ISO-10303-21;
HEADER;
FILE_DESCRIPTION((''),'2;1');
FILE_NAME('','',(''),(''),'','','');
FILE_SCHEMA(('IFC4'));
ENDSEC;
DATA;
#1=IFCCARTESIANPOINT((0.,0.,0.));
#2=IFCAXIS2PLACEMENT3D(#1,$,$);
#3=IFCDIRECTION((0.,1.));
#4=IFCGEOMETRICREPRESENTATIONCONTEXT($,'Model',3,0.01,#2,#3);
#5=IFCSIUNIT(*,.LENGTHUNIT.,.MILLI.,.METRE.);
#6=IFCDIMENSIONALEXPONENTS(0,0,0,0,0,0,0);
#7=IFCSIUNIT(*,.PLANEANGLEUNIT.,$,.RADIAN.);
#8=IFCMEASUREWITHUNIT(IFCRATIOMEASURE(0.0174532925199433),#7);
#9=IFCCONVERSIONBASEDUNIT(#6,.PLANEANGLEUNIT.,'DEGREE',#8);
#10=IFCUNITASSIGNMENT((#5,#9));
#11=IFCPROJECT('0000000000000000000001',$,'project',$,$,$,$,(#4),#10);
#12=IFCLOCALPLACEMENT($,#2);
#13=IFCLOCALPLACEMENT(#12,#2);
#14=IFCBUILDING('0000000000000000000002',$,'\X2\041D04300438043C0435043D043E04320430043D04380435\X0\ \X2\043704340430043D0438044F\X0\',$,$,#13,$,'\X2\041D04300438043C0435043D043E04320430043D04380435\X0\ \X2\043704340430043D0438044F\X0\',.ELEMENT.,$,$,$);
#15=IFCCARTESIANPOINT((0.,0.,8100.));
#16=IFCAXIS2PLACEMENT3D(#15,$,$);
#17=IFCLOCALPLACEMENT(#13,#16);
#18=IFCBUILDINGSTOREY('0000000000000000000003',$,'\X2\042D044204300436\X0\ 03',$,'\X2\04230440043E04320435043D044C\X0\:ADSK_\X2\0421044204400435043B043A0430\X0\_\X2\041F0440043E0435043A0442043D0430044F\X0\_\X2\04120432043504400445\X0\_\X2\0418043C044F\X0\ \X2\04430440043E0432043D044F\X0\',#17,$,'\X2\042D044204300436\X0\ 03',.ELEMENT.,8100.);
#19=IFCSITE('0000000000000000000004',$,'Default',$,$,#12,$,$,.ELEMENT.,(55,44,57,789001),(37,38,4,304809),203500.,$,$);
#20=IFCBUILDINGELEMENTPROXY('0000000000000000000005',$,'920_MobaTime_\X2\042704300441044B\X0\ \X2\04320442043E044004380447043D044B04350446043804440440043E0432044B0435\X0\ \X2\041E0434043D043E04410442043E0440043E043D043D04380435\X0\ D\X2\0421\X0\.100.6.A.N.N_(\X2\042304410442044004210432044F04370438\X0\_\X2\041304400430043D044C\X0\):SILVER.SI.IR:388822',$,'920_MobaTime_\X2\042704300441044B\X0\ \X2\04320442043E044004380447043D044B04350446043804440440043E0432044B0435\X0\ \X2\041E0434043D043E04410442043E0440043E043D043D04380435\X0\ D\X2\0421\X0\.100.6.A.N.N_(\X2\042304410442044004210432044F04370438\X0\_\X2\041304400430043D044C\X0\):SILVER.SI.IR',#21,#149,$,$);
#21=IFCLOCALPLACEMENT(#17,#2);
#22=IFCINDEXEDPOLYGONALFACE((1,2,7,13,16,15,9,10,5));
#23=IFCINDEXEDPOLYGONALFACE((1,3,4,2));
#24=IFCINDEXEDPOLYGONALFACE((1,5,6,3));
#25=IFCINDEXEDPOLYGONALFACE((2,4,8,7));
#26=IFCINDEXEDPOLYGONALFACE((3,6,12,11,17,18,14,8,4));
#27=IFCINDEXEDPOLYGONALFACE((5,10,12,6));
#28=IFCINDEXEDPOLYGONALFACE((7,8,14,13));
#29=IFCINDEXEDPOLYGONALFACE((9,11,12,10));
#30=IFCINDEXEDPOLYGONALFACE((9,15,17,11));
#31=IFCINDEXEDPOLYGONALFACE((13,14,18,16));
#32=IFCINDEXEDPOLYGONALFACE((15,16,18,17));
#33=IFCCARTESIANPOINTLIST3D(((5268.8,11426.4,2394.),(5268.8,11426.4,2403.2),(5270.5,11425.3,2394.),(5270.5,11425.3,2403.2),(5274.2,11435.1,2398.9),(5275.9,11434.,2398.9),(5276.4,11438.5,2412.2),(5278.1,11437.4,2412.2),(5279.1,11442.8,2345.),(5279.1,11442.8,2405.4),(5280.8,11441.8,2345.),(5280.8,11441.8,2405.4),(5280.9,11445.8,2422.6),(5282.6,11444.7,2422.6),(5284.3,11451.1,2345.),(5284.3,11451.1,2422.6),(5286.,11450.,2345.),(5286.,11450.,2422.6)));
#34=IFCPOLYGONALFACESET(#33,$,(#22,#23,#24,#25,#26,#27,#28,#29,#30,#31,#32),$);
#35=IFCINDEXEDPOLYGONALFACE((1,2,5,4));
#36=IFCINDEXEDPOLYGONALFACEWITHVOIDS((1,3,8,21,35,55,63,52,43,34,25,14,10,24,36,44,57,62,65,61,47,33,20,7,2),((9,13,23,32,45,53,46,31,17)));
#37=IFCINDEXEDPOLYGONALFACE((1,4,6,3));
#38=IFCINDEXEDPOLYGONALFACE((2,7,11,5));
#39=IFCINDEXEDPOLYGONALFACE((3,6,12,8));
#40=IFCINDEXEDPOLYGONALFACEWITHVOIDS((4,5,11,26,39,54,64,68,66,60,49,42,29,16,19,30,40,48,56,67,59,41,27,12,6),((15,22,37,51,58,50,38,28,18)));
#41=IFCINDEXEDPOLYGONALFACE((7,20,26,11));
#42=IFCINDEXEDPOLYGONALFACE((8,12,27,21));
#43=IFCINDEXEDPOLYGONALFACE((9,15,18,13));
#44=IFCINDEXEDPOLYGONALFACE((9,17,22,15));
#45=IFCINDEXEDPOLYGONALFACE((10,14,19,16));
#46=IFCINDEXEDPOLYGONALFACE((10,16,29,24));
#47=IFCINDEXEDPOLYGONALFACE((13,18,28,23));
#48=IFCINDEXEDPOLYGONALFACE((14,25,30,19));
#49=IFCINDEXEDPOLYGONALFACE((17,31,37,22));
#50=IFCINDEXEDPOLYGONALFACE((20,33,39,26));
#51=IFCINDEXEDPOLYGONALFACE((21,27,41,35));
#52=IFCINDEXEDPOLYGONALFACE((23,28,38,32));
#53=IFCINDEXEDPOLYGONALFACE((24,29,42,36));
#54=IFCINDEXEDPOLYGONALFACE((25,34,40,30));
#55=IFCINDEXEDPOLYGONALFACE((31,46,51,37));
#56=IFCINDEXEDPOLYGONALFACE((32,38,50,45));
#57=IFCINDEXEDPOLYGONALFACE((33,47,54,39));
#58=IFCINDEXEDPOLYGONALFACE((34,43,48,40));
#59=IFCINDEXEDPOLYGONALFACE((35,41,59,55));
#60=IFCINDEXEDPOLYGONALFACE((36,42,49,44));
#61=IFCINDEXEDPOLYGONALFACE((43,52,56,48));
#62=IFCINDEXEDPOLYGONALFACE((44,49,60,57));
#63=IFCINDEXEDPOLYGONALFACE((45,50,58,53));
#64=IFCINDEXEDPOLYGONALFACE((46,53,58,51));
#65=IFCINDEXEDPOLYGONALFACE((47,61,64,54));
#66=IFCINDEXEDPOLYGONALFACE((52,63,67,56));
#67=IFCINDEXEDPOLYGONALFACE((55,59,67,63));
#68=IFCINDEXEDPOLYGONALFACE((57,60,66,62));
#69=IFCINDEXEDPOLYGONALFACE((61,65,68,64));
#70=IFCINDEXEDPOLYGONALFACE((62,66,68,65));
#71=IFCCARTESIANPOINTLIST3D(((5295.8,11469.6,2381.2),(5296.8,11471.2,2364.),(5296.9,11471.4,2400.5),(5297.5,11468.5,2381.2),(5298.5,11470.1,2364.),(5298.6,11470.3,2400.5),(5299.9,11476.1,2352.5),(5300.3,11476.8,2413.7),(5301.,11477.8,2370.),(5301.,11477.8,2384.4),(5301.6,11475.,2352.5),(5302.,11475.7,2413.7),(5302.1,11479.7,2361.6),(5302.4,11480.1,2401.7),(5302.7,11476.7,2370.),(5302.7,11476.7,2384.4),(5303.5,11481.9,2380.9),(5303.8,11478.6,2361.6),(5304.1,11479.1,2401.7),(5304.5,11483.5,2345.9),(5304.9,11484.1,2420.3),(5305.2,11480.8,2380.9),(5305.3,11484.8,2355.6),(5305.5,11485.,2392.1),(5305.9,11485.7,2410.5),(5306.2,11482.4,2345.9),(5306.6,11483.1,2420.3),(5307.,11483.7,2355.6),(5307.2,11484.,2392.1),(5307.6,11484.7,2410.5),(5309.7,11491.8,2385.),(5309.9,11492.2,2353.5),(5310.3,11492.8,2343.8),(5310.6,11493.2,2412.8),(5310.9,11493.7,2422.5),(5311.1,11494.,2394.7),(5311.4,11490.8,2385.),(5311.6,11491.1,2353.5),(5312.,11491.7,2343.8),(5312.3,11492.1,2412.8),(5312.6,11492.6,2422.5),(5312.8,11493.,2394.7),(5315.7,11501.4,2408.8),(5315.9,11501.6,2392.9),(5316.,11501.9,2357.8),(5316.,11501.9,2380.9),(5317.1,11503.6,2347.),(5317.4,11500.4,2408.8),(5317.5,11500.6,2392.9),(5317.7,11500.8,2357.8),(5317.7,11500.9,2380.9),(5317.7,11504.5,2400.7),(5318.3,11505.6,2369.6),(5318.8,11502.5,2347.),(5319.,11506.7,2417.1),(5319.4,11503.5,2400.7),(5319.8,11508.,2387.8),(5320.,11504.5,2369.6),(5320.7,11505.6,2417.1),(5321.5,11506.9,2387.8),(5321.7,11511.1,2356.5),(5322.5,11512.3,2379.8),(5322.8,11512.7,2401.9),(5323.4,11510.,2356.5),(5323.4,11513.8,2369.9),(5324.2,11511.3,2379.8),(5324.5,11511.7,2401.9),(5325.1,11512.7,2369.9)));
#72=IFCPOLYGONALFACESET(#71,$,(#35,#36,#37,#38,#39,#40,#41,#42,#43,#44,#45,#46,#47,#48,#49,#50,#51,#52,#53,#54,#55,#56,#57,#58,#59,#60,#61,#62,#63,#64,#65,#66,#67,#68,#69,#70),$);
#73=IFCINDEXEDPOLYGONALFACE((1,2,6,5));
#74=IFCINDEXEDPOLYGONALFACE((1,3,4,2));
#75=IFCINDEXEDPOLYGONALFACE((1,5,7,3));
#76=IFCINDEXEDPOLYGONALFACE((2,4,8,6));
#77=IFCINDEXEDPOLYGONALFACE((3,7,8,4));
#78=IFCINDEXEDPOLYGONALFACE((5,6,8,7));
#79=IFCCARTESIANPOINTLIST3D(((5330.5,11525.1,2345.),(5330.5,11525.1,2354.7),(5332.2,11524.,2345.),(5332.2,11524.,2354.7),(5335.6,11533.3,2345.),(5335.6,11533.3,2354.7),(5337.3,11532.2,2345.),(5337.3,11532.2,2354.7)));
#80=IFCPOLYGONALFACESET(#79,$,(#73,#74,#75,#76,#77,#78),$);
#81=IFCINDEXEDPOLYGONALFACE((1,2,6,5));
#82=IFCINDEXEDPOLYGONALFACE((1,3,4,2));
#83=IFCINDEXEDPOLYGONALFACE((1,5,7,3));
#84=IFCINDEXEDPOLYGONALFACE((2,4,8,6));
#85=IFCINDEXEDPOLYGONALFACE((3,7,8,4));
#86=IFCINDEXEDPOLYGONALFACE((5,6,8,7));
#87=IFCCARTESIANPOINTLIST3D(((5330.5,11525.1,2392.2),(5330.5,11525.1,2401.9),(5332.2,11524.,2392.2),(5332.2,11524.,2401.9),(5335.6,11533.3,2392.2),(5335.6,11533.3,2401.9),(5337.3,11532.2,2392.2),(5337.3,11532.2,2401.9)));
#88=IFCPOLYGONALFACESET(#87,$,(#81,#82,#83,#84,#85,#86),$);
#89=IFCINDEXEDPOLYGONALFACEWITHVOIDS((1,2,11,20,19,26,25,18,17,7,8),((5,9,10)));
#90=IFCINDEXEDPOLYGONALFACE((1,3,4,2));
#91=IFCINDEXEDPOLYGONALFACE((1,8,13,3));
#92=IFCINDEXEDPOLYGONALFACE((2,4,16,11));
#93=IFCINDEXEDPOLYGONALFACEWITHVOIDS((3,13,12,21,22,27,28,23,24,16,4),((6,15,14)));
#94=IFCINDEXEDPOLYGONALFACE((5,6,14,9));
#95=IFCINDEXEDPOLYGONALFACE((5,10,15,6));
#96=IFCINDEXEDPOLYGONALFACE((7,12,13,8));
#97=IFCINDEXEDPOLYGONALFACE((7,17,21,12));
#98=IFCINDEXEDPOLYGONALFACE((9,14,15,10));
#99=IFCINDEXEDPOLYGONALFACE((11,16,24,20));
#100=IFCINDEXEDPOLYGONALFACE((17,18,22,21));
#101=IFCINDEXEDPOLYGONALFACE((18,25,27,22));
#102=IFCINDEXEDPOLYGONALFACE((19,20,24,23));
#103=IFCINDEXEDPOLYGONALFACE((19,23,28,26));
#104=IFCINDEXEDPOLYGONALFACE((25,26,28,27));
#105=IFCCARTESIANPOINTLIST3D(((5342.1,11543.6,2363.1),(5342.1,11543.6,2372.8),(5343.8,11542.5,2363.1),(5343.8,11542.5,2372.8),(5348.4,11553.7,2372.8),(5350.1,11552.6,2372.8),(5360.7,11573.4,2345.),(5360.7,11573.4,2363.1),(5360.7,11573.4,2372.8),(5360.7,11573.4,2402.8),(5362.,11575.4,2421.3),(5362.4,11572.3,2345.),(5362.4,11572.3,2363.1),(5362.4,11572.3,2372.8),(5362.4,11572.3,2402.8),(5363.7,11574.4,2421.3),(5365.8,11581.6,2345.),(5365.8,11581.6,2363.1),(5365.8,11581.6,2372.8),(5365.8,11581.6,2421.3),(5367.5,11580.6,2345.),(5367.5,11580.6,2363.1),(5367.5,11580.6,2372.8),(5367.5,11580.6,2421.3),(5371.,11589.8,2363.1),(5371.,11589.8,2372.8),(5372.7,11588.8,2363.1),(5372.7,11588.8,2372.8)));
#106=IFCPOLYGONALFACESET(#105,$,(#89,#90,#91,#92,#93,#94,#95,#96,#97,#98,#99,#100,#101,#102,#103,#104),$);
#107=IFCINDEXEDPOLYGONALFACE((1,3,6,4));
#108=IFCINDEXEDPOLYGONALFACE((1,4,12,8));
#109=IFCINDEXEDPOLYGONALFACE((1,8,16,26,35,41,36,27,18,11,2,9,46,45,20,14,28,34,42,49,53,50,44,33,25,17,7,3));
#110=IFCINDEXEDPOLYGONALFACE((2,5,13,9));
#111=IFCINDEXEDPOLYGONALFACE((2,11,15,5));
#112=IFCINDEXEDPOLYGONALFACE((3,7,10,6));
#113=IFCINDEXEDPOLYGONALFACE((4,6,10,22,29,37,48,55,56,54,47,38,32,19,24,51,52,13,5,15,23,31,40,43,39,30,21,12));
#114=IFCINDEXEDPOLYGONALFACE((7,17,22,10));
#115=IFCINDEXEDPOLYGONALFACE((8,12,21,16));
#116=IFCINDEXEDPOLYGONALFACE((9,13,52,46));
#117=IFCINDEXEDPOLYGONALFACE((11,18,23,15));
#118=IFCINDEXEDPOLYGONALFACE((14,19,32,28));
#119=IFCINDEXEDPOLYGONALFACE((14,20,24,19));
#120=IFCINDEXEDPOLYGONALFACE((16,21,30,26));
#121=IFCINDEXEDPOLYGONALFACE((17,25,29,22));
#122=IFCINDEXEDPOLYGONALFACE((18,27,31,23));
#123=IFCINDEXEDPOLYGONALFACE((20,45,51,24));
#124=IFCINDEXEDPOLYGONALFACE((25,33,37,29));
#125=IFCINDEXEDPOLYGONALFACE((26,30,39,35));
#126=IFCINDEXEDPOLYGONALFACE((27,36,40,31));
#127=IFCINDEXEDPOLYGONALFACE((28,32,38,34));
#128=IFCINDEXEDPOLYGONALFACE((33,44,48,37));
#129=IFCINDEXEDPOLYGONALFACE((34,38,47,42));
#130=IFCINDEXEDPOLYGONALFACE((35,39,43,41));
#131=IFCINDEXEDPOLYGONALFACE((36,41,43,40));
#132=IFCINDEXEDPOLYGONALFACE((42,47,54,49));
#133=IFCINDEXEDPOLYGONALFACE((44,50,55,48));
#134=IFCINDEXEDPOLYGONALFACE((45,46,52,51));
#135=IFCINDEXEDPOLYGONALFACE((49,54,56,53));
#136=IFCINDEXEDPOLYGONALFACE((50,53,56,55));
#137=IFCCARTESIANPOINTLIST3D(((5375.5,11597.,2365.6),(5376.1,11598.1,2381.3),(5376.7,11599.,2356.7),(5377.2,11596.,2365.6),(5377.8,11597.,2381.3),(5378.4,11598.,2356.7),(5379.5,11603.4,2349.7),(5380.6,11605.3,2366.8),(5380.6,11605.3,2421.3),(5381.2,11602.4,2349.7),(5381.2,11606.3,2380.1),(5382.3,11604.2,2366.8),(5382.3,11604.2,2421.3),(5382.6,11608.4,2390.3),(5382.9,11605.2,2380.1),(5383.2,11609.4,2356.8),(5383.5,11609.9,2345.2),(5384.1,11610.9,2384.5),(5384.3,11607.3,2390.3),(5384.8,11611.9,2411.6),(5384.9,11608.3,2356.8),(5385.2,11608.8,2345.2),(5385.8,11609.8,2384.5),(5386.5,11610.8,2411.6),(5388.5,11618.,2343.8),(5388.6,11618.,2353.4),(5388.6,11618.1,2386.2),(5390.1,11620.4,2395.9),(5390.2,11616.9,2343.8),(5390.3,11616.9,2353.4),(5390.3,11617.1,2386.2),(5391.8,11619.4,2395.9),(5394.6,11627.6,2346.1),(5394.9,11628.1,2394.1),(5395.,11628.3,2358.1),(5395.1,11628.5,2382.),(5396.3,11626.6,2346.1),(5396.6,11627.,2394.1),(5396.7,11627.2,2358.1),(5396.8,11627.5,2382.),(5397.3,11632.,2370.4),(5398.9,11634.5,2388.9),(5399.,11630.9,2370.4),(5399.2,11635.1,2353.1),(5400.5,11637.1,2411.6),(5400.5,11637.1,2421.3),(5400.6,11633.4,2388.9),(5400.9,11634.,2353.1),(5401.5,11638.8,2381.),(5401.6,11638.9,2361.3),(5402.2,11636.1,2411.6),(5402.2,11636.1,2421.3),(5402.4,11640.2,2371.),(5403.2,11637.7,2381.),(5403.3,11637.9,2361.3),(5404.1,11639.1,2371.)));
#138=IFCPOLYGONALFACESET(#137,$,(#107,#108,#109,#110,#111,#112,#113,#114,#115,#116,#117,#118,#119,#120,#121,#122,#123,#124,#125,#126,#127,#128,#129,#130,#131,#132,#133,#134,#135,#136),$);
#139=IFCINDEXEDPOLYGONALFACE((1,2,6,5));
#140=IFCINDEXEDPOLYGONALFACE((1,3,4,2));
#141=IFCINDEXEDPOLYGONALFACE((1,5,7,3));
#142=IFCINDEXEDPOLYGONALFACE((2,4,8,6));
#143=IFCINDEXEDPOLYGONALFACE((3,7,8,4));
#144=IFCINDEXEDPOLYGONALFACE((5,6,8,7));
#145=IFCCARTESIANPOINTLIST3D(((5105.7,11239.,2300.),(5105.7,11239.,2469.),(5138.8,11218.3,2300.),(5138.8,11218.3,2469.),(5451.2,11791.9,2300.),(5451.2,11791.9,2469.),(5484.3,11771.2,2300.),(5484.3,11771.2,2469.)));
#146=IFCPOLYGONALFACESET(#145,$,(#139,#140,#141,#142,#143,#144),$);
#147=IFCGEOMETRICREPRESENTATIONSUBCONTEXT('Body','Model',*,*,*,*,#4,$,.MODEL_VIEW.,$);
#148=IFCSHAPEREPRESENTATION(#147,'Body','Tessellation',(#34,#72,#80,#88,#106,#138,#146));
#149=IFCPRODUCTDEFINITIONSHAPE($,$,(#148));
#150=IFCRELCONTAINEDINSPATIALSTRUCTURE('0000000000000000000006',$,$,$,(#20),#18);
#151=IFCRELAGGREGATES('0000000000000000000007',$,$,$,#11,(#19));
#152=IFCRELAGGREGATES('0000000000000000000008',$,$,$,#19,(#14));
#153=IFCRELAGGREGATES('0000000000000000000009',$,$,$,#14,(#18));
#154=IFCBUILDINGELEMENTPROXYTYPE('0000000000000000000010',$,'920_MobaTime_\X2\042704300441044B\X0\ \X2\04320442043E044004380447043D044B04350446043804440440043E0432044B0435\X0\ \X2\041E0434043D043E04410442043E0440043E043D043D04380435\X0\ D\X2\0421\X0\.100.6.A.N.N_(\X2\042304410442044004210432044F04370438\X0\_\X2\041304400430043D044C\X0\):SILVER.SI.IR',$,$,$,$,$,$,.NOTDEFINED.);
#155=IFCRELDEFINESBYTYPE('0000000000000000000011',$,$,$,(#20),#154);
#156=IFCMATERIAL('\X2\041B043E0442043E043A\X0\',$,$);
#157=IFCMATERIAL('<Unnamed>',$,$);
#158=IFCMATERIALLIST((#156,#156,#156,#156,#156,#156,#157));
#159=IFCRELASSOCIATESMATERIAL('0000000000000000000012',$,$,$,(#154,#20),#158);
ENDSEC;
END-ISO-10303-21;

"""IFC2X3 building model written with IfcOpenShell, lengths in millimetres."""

from ifc_helpers import new_model, entity, si_unit, converted_unit, direction, frame, origin, origin_2d_with_axis, place, context, subcontext, project, spatial, polyline, rectangle, outline, extrude, source, transform, mapped, material, material_list, type_object, type_shapes, element, save


model = new_model("IFC2X3")

# Units and contexts
model_context = context("Model", 3, precision=0.01, world=origin(), true_north=direction((0.0, 1.0)))
body_context = subcontext(model_context, "Body", "Model", "MODEL_VIEW")
ifc_project = project(units=[si_unit("LENGTHUNIT", "METRE", prefix="MILLI"), converted_unit("PLANEANGLEUNIT", "DEGREE", entity("IfcRatioMeasure", 0.0174532925199433), si_unit("PLANEANGLEUNIT", "RADIAN"), dimensions=[0, 0, 0, 0, 0, 0, 0])], contexts=[model_context])

# Site, building, storey
site_placement = place(None, origin())
site = spatial("IfcSite", under=ifc_project, at=site_placement, Name="Default", CompositionType="ELEMENT", RefLatitude=(55, 44, 57, 789001), RefLongitude=(37, 38, 4, 304809), RefElevation=203500.0)
building_placement = place(site_placement, origin())
building = spatial("IfcBuilding", under=site, at=building_placement, Name="Наименование здания", LongName="Наименование здания", CompositionType="ELEMENT")
storey_placement = place(building_placement, frame((0.0, 0.0, 8100.0)))
storey = spatial("IfcBuildingStorey", under=building, at=storey_placement, Name="Этаж 03", ObjectType="Уровень:ADSK_Стрелка_Проектная_Вверх_Имя уровня", LongName="Этаж 03", CompositionType="ELEMENT", Elevation=8100.0)

# Building element proxy
ifc_material_1 = material(Name="Лоток")
ifc_material_2 = material(Name="<Unnamed>")
ifc_material_list_1 = material_list([ifc_material_1, ifc_material_1, ifc_material_1, ifc_material_1, ifc_material_1, ifc_material_1, ifc_material_2])
building_element_proxy_type = type_object("IfcBuildingElementProxyType", Name="920_MobaTime_Часы вторичныецифровые Односторонние DС.100.6.A.N.N_(УстрСвязи_Грань):SILVER.SI.IR", PredefinedType="NOTDEFINED", material=ifc_material_list_1)
shared_shape = source(origin(), body_context, "Body", "SweptSolid", [
    extrude(outline(polyline([(-49.3, -13.1), (28.2, -13.1), (28.2, -6.8), (17.9, 1.8), (8.8, 16.0), (-0.3, 16.0), (4.6, 5.8), (11.1, -3.4), (-49.3, -3.4), (-49.3, -13.1)])), frame((-64.6, 9.8, 39.0), z_axis=(0.0, 0.0, 1.0), x_axis=(0.0, 1.0, 0.0)), (0.0, 0.0, 1.0), 2.0),
    extrude(outline(polyline([(2.2, -27.6), (19.0, -27.6), (30.5, -16.1), (33.3, -4.9), (31.0, 5.8), (21.8, 17.2), (5.2, 27.3), (-11.1, 33.0), (-24.0, 32.7), (-33.6, 27.6), (-40.3, 18.6), (-42.8, 5.7), (-38.0, -6.3), (-27.2, -14.9), (-17.5, -17.7), (-8.2, -16.4), (-0.3, -11.9), (5.1, -4.5), (7.3, 6.2), (4.0, 17.2), (18.4, 7.3), (23.6, -2.4), (22.0, -11.4), (14.2, -18.4), (5.3, -18.3), (2.2, -27.6)]), holes=[polyline([(-9.0, 23.3), (-1.3, 14.3), (-2.5, 2.0), (-11.4, -7.0), (-23.4, -6.0), (-32.2, 2.9), (-31.2, 15.1), (-25.6, 22.1), (-17.5, 24.9), (-9.0, 23.3)])]), frame((-2.7, 3.6, 39.0), z_axis=(0.0, 0.0, 1.0), x_axis=(-0.427649, 0.903945, 0.0)), (0.0, 0.0, 1.0), 2.0),
    extrude(rectangle(XDim=9.7, YDim=9.7, at=origin_2d_with_axis()), frame((40.6, -34.7, 39.0)), (0.0, 0.0, 1.0), 2.0),
    extrude(rectangle(XDim=9.7, YDim=9.7, at=origin_2d_with_axis()), frame((40.6, 12.6, 39.0)), (0.0, 0.0, 1.0), 2.0),
    extrude(outline(polyline([(-0.9, -28.1), (8.8, -28.1), (8.8, -9.9), (18.5, -9.9), (18.5, -0.2), (8.8, -0.2), (8.8, 48.3), (1.5, 48.3), (-36.0, -0.2), (-36.0, -9.9), (-0.9, -9.9), (-0.9, -28.1)]), holes=[polyline([(-0.9, -0.2), (-24.1, -0.2), (-0.9, 29.7), (-0.9, -0.2)])]), frame((93.6, -11.4, 39.0)), (0.0, 0.0, 1.0), 2.0),
    extrude(outline(polyline([(3.3, -28.3), (12.5, -28.3), (20.5, -25.0), (26.8, -18.9), (30.7, -10.0), (31.4, 1.6), (26.9, 11.8), (20.1, 18.4), (11.1, 22.3), (1.0, 23.3), (-7.9, 20.4), (-14.9, 14.5), (-18.9, 6.2), (-17.1, -9.0), (-36.7, 0.5), (-29.1, 29.2), (-38.5, 31.7), (-48.1, -4.6), (-11.6, -23.1), (-8.0, -14.0), (-10.8, -7.6), (-10.2, 1.1), (-3.0, 11.8), (9.2, 12.8), (20.0, 5.5), (21.4, -7.5), (15.5, -16.4), (4.6, -18.6), (3.3, -28.3)])), frame((147.1, -8.5, 39.0), z_axis=(0.0, 0.0, 1.0), x_axis=(0.256974, -0.966418, 0.0)), (0.0, 0.0, 1.0), 2.0),
    extrude(rectangle(XDim=652.0, YDim=169.0, at=origin_2d_with_axis()), frame((0.0, 0.0, 0.0), z_axis=(0.0, 0.0, 1.0), x_axis=(-1.0, 0.0, 0.0)), (0.0, 0.0, 1.0), 39.0),
])
type_shapes(building_element_proxy_type, [shared_shape])
proxy_placement = place(storey_placement, frame((5278.5, 11515.4, 2384.5), z_axis=(0.848048, -0.529919, 0.0), x_axis=(0.529919, 0.848048, 0.0)))
element("IfcBuildingElementProxy", 1, at=proxy_placement, inside=storey, type_object=building_element_proxy_type, material=ifc_material_list_1, Name="920_MobaTime_Часы вторичныецифровые Односторонние DС.100.6.A.N.N_(УстрСвязи_Грань):SILVER.SI.IR:388822", ObjectType="920_MobaTime_Часы вторичныецифровые Односторонние DС.100.6.A.N.N_(УстрСвязи_Грань):SILVER.SI.IR", context=body_context, shape_type="MappedRepresentation", body=[
    mapped(shared_shape, transform((0.0, 0.0, 0.0), scale=1.0)),
])

save(model, "model.ifc")
